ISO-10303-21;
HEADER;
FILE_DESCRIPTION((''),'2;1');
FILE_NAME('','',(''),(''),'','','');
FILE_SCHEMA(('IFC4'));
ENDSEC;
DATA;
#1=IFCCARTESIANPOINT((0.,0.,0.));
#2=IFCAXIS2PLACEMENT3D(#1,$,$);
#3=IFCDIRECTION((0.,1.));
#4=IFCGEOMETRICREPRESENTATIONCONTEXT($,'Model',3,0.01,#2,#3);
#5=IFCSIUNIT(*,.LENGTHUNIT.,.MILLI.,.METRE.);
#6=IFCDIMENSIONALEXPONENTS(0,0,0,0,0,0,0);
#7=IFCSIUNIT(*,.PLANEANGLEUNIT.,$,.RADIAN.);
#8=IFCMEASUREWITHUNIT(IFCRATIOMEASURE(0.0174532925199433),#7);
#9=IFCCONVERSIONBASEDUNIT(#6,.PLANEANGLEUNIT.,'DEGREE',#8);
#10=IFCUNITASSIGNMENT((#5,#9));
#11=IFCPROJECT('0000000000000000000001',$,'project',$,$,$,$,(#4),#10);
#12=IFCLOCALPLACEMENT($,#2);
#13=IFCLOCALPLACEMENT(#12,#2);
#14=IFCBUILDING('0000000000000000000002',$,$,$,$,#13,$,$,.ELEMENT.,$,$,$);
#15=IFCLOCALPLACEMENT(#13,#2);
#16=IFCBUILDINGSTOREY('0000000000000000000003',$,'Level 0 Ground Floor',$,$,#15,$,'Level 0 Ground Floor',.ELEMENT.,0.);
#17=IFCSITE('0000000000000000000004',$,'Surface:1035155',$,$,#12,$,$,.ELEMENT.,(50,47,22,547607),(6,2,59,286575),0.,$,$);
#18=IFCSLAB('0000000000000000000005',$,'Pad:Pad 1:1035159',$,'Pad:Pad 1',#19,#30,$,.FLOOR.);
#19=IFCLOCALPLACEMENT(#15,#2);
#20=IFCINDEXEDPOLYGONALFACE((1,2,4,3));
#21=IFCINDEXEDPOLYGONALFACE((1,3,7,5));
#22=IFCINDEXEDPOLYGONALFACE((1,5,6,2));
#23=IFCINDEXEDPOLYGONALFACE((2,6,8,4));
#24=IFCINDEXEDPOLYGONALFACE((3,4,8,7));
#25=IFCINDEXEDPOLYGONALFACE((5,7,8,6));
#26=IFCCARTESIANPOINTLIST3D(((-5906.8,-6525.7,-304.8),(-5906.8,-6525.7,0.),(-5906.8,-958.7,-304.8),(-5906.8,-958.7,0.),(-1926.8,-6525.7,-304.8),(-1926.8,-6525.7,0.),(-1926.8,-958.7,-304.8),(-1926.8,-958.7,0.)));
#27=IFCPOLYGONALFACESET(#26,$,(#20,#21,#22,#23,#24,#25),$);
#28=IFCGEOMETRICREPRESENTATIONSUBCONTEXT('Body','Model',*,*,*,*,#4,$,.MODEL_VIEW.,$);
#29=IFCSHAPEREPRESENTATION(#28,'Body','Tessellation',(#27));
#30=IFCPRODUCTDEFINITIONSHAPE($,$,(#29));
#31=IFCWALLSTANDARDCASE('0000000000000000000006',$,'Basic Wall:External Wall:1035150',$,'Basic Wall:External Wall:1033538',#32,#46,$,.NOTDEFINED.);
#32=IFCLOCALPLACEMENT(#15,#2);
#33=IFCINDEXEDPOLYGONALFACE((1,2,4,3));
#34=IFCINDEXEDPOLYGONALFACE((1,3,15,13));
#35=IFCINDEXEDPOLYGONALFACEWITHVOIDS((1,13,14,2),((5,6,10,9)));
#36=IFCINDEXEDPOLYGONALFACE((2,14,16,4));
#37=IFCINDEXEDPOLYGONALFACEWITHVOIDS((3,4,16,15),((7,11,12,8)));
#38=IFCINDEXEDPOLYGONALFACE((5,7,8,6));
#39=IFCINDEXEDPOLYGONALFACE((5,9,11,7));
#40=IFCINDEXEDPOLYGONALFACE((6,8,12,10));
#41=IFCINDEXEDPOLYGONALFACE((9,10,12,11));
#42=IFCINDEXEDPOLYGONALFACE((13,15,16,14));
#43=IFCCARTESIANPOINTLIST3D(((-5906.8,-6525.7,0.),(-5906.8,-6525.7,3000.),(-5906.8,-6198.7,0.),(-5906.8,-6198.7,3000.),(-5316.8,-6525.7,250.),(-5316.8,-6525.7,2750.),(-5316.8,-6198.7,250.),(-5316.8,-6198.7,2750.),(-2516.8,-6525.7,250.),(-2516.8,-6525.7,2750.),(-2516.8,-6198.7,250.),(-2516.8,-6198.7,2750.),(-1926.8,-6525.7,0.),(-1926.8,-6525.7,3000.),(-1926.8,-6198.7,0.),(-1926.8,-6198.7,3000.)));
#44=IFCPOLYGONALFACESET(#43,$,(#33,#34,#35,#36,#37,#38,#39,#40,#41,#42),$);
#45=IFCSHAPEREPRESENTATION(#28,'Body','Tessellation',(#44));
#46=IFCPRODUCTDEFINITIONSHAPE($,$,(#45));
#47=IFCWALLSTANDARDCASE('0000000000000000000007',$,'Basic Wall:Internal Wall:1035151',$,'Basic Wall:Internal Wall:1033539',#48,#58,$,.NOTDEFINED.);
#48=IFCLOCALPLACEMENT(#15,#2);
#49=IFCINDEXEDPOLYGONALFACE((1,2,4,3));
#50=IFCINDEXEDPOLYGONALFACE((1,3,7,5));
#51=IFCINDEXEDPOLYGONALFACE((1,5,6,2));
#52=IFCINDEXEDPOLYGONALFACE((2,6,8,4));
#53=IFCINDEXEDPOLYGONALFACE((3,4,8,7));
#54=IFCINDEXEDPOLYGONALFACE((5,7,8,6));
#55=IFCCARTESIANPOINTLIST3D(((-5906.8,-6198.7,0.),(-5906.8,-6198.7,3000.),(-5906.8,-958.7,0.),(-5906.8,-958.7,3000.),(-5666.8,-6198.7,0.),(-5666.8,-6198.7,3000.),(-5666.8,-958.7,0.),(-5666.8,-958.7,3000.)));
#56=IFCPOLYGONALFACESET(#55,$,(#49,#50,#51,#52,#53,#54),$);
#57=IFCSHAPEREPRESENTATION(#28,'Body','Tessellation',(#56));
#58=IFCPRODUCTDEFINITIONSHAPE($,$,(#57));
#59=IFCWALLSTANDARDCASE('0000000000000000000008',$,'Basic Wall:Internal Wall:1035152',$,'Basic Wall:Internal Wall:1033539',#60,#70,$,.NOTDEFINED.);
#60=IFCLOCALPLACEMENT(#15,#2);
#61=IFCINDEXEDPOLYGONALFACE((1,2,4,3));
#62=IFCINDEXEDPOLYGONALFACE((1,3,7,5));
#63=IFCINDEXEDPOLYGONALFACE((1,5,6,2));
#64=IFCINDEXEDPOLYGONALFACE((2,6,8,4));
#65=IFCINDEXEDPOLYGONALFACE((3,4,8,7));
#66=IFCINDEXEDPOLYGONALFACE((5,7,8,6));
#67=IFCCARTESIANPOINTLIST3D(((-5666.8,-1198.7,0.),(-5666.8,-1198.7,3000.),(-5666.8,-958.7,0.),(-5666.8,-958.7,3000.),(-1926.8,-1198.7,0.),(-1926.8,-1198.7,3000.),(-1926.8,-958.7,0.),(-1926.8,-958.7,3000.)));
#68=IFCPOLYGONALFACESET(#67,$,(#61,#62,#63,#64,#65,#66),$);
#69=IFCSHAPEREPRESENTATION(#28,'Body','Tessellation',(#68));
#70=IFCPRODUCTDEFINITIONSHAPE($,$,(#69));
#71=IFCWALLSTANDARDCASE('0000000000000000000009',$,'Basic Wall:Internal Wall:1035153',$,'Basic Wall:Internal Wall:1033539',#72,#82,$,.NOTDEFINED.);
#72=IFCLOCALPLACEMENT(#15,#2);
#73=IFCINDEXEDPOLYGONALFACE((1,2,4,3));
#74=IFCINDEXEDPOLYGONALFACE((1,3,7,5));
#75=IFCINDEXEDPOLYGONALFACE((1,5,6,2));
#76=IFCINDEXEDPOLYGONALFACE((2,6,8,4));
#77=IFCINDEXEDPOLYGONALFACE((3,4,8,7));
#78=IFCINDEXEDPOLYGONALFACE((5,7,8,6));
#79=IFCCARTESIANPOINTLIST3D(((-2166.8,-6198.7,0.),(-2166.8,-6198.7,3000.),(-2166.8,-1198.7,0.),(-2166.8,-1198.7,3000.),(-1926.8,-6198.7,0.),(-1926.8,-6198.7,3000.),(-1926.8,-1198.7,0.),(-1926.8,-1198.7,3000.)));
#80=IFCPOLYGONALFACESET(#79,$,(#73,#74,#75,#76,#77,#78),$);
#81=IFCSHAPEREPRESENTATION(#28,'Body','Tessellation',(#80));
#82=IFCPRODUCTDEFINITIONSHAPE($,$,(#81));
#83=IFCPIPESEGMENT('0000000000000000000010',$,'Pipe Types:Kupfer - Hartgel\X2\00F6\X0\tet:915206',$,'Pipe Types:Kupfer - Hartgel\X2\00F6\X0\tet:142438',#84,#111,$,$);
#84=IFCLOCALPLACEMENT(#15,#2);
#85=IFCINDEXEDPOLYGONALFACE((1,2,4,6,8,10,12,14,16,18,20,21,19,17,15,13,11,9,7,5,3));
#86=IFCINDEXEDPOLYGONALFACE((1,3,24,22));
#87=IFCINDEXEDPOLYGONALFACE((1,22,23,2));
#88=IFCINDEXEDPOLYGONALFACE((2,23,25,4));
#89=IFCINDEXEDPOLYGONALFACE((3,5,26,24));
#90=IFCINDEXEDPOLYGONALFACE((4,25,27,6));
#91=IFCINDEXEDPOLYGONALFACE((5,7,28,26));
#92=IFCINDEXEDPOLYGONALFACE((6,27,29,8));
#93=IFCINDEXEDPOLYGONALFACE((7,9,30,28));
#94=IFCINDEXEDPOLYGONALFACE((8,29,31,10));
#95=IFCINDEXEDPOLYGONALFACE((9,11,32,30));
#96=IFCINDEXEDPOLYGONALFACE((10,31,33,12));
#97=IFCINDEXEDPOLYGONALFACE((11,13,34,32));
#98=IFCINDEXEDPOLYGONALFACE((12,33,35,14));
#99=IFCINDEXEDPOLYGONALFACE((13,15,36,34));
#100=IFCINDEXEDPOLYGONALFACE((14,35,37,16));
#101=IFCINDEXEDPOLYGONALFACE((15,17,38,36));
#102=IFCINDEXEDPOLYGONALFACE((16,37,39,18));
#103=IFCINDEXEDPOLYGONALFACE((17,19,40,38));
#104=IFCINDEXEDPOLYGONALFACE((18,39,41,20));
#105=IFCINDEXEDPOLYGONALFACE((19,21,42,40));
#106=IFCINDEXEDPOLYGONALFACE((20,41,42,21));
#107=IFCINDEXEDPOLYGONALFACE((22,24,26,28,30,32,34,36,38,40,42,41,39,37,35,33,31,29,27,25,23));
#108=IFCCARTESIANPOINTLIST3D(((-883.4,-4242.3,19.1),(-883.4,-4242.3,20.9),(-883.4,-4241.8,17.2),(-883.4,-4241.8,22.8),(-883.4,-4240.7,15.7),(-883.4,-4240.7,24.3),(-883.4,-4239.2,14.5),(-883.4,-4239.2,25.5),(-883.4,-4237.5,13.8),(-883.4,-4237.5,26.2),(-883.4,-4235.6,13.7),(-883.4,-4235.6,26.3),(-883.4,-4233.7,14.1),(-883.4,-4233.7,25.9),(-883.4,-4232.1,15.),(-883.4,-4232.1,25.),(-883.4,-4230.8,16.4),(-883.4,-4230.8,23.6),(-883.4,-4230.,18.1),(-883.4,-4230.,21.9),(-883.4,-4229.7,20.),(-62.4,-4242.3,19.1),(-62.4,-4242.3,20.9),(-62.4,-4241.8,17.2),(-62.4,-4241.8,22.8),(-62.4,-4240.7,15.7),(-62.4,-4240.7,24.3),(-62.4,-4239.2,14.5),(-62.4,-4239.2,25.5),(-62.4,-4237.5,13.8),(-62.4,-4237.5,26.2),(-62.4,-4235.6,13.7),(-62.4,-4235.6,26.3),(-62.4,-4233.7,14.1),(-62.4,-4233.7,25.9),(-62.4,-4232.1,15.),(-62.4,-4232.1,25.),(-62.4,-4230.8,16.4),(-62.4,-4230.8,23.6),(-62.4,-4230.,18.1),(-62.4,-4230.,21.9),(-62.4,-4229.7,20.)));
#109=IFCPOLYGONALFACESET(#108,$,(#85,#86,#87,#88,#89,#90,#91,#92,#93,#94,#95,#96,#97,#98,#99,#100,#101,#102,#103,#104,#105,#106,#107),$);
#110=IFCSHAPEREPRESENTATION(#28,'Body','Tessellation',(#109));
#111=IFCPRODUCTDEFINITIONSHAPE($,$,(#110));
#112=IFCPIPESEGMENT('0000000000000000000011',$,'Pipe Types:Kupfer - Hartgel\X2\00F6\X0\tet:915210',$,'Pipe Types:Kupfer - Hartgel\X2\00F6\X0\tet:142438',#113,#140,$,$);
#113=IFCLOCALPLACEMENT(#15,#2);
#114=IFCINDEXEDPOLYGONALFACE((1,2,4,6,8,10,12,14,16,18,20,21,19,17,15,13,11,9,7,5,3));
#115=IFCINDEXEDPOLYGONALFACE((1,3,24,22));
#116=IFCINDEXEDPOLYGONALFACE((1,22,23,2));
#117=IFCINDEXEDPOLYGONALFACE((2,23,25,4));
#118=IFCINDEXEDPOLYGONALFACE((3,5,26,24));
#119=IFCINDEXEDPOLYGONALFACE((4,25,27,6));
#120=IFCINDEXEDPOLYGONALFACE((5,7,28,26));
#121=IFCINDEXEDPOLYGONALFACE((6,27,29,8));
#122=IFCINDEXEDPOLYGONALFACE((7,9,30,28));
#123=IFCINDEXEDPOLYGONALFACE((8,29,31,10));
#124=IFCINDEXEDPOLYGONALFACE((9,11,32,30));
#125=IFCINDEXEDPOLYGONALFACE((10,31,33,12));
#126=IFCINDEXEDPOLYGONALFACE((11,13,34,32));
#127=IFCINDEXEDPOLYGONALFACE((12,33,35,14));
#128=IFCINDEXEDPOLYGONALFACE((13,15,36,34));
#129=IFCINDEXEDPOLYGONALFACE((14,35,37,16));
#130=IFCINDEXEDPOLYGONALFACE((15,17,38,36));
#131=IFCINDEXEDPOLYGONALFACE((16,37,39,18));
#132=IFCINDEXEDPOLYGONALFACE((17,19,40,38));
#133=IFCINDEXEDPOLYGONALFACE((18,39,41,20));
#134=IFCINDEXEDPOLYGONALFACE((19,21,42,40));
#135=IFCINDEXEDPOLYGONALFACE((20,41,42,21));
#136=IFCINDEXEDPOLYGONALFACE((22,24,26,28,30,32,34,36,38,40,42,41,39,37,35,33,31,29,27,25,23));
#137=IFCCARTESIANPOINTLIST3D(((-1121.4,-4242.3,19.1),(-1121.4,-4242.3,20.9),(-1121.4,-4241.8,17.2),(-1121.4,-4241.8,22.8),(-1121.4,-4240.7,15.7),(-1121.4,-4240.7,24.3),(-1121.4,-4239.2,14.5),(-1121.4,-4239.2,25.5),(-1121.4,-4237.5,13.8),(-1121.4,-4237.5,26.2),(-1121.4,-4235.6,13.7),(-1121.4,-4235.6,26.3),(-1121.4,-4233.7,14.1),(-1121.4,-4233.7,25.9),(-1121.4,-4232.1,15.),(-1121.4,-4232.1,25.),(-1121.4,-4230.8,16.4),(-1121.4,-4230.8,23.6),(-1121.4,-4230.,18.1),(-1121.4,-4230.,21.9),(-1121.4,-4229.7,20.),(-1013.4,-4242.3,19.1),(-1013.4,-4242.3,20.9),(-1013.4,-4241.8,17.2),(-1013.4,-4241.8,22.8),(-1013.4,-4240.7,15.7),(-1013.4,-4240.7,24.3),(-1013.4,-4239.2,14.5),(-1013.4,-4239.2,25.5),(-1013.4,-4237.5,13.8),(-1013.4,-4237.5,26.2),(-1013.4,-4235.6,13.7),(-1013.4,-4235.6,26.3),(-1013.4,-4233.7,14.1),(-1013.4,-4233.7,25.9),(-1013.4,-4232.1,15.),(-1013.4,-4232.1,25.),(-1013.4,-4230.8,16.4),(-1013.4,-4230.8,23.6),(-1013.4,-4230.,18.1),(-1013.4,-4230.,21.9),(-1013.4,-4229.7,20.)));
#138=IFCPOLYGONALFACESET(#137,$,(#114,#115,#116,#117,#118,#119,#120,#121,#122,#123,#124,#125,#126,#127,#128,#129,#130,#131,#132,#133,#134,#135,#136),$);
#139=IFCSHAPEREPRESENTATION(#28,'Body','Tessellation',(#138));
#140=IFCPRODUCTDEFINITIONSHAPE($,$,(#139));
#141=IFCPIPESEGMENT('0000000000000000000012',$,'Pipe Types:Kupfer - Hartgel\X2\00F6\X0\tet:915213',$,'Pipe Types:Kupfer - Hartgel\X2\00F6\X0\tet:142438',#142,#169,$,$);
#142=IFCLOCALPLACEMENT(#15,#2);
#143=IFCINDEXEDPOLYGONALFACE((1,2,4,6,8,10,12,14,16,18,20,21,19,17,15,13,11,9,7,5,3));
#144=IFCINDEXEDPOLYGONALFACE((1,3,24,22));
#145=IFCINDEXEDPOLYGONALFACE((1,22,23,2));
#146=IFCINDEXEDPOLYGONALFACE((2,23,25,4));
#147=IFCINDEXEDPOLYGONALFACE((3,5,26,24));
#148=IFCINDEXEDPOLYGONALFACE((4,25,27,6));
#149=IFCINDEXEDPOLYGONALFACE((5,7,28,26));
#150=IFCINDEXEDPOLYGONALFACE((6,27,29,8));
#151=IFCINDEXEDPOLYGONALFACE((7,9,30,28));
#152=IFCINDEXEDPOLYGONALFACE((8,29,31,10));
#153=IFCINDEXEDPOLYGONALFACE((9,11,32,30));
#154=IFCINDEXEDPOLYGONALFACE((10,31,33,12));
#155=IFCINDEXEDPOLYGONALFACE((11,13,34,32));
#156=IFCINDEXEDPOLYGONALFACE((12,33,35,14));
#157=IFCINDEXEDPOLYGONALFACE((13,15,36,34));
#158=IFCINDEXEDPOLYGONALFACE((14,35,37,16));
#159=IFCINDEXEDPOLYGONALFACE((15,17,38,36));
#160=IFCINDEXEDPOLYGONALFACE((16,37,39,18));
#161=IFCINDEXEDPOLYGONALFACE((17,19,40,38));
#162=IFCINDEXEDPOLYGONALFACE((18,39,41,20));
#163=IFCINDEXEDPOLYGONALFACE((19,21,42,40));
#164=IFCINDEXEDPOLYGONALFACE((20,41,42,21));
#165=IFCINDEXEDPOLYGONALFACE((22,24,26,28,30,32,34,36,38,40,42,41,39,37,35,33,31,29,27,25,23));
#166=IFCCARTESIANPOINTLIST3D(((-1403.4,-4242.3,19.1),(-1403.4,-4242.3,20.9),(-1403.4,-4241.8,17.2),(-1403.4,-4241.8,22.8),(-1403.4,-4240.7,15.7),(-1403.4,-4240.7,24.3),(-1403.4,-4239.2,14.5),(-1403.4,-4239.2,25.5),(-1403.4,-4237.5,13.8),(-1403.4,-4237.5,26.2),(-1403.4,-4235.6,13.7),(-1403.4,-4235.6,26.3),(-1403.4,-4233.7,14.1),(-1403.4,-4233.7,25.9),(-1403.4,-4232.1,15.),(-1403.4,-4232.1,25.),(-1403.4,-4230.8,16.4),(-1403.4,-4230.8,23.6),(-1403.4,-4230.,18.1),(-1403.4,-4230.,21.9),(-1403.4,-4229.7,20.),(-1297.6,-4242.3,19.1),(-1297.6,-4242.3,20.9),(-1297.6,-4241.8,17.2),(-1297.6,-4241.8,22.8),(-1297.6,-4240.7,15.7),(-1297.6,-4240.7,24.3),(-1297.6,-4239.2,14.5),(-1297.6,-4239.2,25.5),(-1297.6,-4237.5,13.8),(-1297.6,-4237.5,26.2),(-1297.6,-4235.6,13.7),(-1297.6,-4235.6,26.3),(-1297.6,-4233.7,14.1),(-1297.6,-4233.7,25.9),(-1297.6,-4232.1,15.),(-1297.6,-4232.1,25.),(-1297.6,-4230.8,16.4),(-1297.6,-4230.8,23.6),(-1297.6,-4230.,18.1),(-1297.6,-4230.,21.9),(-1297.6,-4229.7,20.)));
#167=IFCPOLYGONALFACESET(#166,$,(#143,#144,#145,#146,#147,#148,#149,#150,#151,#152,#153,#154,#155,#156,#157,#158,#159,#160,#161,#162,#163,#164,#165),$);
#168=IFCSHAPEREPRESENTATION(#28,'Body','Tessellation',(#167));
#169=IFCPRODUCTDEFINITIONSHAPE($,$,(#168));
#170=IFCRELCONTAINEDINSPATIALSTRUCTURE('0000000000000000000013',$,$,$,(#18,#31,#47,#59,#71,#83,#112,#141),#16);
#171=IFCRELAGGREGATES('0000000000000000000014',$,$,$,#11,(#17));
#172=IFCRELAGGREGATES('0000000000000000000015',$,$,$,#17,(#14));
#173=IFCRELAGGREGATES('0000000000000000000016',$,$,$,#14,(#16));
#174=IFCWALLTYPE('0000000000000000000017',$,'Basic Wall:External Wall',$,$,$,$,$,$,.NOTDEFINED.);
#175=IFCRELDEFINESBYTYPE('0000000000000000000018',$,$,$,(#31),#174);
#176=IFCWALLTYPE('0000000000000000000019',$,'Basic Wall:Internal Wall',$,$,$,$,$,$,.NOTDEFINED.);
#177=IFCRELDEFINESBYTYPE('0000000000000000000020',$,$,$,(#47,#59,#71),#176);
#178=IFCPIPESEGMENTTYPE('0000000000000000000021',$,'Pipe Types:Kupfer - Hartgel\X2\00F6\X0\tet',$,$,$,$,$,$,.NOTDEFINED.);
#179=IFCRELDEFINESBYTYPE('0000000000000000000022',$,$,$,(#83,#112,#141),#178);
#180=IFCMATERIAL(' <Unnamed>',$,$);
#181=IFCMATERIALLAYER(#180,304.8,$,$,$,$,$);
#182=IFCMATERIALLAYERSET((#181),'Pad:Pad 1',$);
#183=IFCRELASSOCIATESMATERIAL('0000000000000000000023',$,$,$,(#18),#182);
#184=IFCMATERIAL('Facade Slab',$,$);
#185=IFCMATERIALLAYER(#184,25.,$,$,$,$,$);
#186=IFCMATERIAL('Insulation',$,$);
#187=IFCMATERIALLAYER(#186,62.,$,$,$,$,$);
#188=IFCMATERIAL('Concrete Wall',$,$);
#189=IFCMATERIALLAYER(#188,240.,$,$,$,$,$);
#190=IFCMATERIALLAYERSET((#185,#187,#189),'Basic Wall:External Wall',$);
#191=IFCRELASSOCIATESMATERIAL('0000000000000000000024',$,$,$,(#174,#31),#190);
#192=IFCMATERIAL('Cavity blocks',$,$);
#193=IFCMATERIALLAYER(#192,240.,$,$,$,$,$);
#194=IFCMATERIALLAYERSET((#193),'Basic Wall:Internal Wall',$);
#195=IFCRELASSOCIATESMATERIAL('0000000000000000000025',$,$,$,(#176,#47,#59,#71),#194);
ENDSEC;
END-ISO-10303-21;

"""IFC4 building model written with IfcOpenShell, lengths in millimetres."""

from ifc_helpers import new_model, entity, si_unit, converted_unit, direction, frame, frame_2d, origin, place, context, subcontext, project, spatial, polyline, rectangle, circle, extrude, clip, bounded_halfspace, material, layer, layer_set, layer_usage, type_object, element, save


model = new_model("IFC4")

# Units and contexts
model_context = context("Model", 3, precision=0.01, world=origin(), true_north=direction((0.0, 1.0)))
body_context = subcontext(model_context, "Body", "Model", "MODEL_VIEW")
ifc_project = project(units=[si_unit("LENGTHUNIT", "METRE", prefix="MILLI"), converted_unit("PLANEANGLEUNIT", "DEGREE", entity("IfcRatioMeasure", 0.0174532925199433), si_unit("PLANEANGLEUNIT", "RADIAN"), dimensions=[0, 0, 0, 0, 0, 0, 0])], contexts=[model_context])

# Site, building, storey
site_placement = place(None, origin())
site = spatial("IfcSite", under=ifc_project, at=site_placement, Name="Surface:1035155", CompositionType="ELEMENT", RefLatitude=(50, 47, 22, 547607), RefLongitude=(6, 2, 59, 286575), RefElevation=0.0)
building_placement = place(site_placement, origin())
building = spatial("IfcBuilding", under=site, at=building_placement, CompositionType="ELEMENT")
storey_placement = place(building_placement, origin())
storey = spatial("IfcBuildingStorey", under=building, at=storey_placement, Name="Level 0 Ground Floor", LongName="Level 0 Ground Floor", CompositionType="ELEMENT", Elevation=0.0)

# Slab
ifc_material_1 = material(Name=" <Unnamed>")
ifc_layer_1 = layer(ifc_material_1, 304.8)
ifc_layer_set_1 = layer_set([ifc_layer_1], Name="Pad:Pad 1")
ifc_layer_usage_1 = layer_usage(ifc_layer_set_1, "AXIS3", "NEGATIVE", 0.0)
slab_placement = place(storey_placement, frame((-5906.8, -6525.7, -304.8)))
element("IfcSlab", 1, at=slab_placement, inside=storey, material=ifc_layer_usage_1, Name="Pad:Pad 1:1035159", ObjectType="Pad:Pad 1", PredefinedType="FLOOR", context=body_context, shape_type="SweptSolid", body=[
    extrude(rectangle(XDim=5567.0, YDim=3980.0, at=frame_2d((0.0, 0.0), x_axis=(0.0, -1.0))), frame((1990.0, 2783.5, 304.8), z_axis=(0.0, 0.0, -1.0), x_axis=(-1.0, 0.0, 0.0)), (0.0, 0.0, 1.0), 304.8),
])

# Wall, opening
ifc_material_2 = material(Name="Facade Slab")
ifc_layer_2 = layer(ifc_material_2, 25.0)
ifc_material_3 = material(Name="Insulation")
ifc_layer_3 = layer(ifc_material_3, 62.0)
ifc_material_4 = material(Name="Concrete Wall")
ifc_layer_4 = layer(ifc_material_4, 240.0)
ifc_layer_set_2 = layer_set([ifc_layer_2, ifc_layer_3, ifc_layer_4], Name="Basic Wall:External Wall")
ifc_layer_usage_2 = layer_usage(ifc_layer_set_2, "AXIS2", "POSITIVE", -163.5)
wall_type_1 = type_object("IfcWallType", Name="Basic Wall:External Wall", PredefinedType="NOTDEFINED", material=ifc_layer_set_2)
wall_1_placement = place(storey_placement, frame((-5906.8, -6362.2, 0.0)))
wall_1 = element("IfcWallStandardCase", 2, at=wall_1_placement, inside=storey, type_object=wall_type_1, material=ifc_layer_usage_2, Name="Basic Wall:External Wall:1035150", ObjectType="Basic Wall:External Wall:1033538", PredefinedType="NOTDEFINED", context=body_context, shape_type="Clipping", body=[
    clip(extrude(rectangle(XDim=3980.0, YDim=327.0, at=frame_2d((1990.0, 0.0), x_axis=(-1.0, 0.0))), origin(), (0.0, 0.0, 1.0), 3000.0), bounded_halfspace(frame((0.0, -163.5, 3000.0), z_axis=(0.0, 0.0, -1.0), x_axis=(0.0, -1.0, 0.0)), True, frame((0.0, -163.5, 3000.0)), polyline([(0.0, 0.0), (3980.0, 0.0), (3980.0, 327.0), (3740.0, 327.0), (240.0, 327.0), (0.0, 327.0), (0.0, 0.0)]))),
])
opening_placement = place(wall_1_placement, frame((590.0, -163.5, 250.0)))
element("IfcOpeningElement", 3, at=opening_placement, cuts=wall_1, ObjectType="Opening", PredefinedType="OPENING", context=body_context, shape_type="SweptSolid", body=[
    extrude(rectangle(XDim=2500.0, YDim=2800.0, at=frame_2d((1250.0, 1400.0), x_axis=(1.0, 0.0))), frame((0.0, 0.0, 0.0), z_axis=(0.0, 1.0, 0.0), x_axis=(0.0, 0.0, 1.0)), (0.0, 0.0, 1.0), 327.0),
])

# Walls
ifc_material_5 = material(Name="Cavity blocks")
ifc_layer_5 = layer(ifc_material_5, 240.0)
ifc_layer_set_3 = layer_set([ifc_layer_5], Name="Basic Wall:Internal Wall")
ifc_layer_usage_3 = layer_usage(ifc_layer_set_3, "AXIS2", "NEGATIVE", 120.0)
wall_type_2 = type_object("IfcWallType", Name="Basic Wall:Internal Wall", PredefinedType="NOTDEFINED", material=ifc_layer_set_3)
wall_2_placement = place(storey_placement, frame((-5786.8, -6198.7, 0.0), z_axis=(0.0, 0.0, 1.0), x_axis=(0.0, 1.0, 0.0)))
element("IfcWallStandardCase", 4, at=wall_2_placement, inside=storey, type_object=wall_type_2, material=ifc_layer_usage_3, Name="Basic Wall:Internal Wall:1035151", ObjectType="Basic Wall:Internal Wall:1033539", PredefinedType="NOTDEFINED", context=body_context, shape_type="Clipping", body=[
    clip(extrude(rectangle(XDim=5240.0, YDim=240.0, at=frame_2d((2620.0, 0.0), x_axis=(-1.0, 0.0))), origin(), (0.0, 0.0, 1.0), 3000.0), bounded_halfspace(frame((0.0, -120.0, 3000.0), z_axis=(0.0, 0.0, -1.0), x_axis=(-1.0, 0.0, 0.0)), True, frame((0.0, -120.0, 3000.0)), polyline([(0.0, 0.0), (5000.0, 0.0), (5240.0, 0.0), (5240.0, 240.0), (0.0, 240.0), (0.0, 0.0)]))),
])
ifc_layer_usage_4 = layer_usage(ifc_layer_set_3, "AXIS2", "NEGATIVE", 120.0)
wall_3_placement = place(storey_placement, frame((-5666.8, -1078.7, 0.0)))
element("IfcWallStandardCase", 5, at=wall_3_placement, inside=storey, type_object=wall_type_2, material=ifc_layer_usage_4, Name="Basic Wall:Internal Wall:1035152", ObjectType="Basic Wall:Internal Wall:1033539", PredefinedType="NOTDEFINED", context=body_context, shape_type="Clipping", body=[
    clip(extrude(rectangle(XDim=3740.0, YDim=240.0, at=frame_2d((1870.0, 0.0), x_axis=(-1.0, 0.0))), origin(), (0.0, 0.0, 1.0), 3000.0), bounded_halfspace(frame((0.0, -120.0, 3000.0), z_axis=(0.0, 0.0, -1.0), x_axis=(0.0, -1.0, 0.0)), True, frame((0.0, -120.0, 3000.0)), polyline([(0.0, 0.0), (3500.0, 0.0), (3740.0, 0.0), (3740.0, 240.0), (0.0, 240.0), (0.0, 0.0)]))),
])
ifc_layer_usage_5 = layer_usage(ifc_layer_set_3, "AXIS2", "NEGATIVE", 120.0)
wall_4_placement = place(storey_placement, frame((-2046.8, -1198.7, 0.0), z_axis=(0.0, 0.0, 1.0), x_axis=(0.0, -1.0, 0.0)))
element("IfcWallStandardCase", 6, at=wall_4_placement, inside=storey, type_object=wall_type_2, material=ifc_layer_usage_5, Name="Basic Wall:Internal Wall:1035153", ObjectType="Basic Wall:Internal Wall:1033539", PredefinedType="NOTDEFINED", context=body_context, shape_type="Clipping", body=[
    clip(extrude(rectangle(XDim=5000.0, YDim=240.0, at=frame_2d((2500.0, 0.0), x_axis=(-1.0, 0.0))), origin(), (0.0, 0.0, 1.0), 3000.0), bounded_halfspace(frame((0.0, -120.0, 3000.0), z_axis=(0.0, 0.0, -1.0), x_axis=(1.0, 0.0, 0.0)), True, frame((0.0, -120.0, 3000.0)), polyline([(0.0, 0.0), (5000.0, 0.0), (5000.0, 240.0), (0.0, 240.0), (0.0, 0.0)]))),
])

# Pipe segments
pipe_segment_type = type_object("IfcPipeSegmentType", Name="Pipe Types:Kupfer - Hartgelötet", PredefinedType="NOTDEFINED")
pipe_segment_1_placement = place(storey_placement, frame((-883.4, -4244.0, 12.1)))
element("IfcPipeSegment", 7, at=pipe_segment_1_placement, inside=storey, type_object=pipe_segment_type, Name="Pipe Types:Kupfer - Hartgelötet:915206", ObjectType="Pipe Types:Kupfer - Hartgelötet:142438", context=body_context, shape_type="SweptSolid", body=[
    extrude(circle(Radius=6.3, at=frame_2d((0.0, 0.0), x_axis=(1.0, 0.0))), frame((0.0, 7.9, 7.9), z_axis=(1.0, 0.0, 0.0), x_axis=(0.0, 1.0, 0.0)), (0.0, 0.0, 1.0), 821.0),
])
pipe_segment_2_placement = place(storey_placement, frame((-1121.4, -4244.0, 12.1)))
element("IfcPipeSegment", 8, at=pipe_segment_2_placement, inside=storey, type_object=pipe_segment_type, Name="Pipe Types:Kupfer - Hartgelötet:915210", ObjectType="Pipe Types:Kupfer - Hartgelötet:142438", context=body_context, shape_type="SweptSolid", body=[
    extrude(circle(Radius=6.3, at=frame_2d((0.0, 0.0), x_axis=(1.0, 0.0))), frame((0.0, 7.9, 7.9), z_axis=(1.0, 0.0, 0.0), x_axis=(0.0, 1.0, 0.0)), (0.0, 0.0, 1.0), 108.0),
])
pipe_segment_3_placement = place(storey_placement, frame((-1403.4, -4244.0, 12.1)))
element("IfcPipeSegment", 9, at=pipe_segment_3_placement, inside=storey, type_object=pipe_segment_type, Name="Pipe Types:Kupfer - Hartgelötet:915213", ObjectType="Pipe Types:Kupfer - Hartgelötet:142438", context=body_context, shape_type="SweptSolid", body=[
    extrude(circle(Radius=6.3, at=frame_2d((0.0, 0.0), x_axis=(1.0, 0.0))), frame((0.0, 7.9, 7.9), z_axis=(1.0, 0.0, 0.0), x_axis=(0.0, 1.0, 0.0)), (0.0, 0.0, 1.0), 105.8),
])

save(model, "model.ifc")
